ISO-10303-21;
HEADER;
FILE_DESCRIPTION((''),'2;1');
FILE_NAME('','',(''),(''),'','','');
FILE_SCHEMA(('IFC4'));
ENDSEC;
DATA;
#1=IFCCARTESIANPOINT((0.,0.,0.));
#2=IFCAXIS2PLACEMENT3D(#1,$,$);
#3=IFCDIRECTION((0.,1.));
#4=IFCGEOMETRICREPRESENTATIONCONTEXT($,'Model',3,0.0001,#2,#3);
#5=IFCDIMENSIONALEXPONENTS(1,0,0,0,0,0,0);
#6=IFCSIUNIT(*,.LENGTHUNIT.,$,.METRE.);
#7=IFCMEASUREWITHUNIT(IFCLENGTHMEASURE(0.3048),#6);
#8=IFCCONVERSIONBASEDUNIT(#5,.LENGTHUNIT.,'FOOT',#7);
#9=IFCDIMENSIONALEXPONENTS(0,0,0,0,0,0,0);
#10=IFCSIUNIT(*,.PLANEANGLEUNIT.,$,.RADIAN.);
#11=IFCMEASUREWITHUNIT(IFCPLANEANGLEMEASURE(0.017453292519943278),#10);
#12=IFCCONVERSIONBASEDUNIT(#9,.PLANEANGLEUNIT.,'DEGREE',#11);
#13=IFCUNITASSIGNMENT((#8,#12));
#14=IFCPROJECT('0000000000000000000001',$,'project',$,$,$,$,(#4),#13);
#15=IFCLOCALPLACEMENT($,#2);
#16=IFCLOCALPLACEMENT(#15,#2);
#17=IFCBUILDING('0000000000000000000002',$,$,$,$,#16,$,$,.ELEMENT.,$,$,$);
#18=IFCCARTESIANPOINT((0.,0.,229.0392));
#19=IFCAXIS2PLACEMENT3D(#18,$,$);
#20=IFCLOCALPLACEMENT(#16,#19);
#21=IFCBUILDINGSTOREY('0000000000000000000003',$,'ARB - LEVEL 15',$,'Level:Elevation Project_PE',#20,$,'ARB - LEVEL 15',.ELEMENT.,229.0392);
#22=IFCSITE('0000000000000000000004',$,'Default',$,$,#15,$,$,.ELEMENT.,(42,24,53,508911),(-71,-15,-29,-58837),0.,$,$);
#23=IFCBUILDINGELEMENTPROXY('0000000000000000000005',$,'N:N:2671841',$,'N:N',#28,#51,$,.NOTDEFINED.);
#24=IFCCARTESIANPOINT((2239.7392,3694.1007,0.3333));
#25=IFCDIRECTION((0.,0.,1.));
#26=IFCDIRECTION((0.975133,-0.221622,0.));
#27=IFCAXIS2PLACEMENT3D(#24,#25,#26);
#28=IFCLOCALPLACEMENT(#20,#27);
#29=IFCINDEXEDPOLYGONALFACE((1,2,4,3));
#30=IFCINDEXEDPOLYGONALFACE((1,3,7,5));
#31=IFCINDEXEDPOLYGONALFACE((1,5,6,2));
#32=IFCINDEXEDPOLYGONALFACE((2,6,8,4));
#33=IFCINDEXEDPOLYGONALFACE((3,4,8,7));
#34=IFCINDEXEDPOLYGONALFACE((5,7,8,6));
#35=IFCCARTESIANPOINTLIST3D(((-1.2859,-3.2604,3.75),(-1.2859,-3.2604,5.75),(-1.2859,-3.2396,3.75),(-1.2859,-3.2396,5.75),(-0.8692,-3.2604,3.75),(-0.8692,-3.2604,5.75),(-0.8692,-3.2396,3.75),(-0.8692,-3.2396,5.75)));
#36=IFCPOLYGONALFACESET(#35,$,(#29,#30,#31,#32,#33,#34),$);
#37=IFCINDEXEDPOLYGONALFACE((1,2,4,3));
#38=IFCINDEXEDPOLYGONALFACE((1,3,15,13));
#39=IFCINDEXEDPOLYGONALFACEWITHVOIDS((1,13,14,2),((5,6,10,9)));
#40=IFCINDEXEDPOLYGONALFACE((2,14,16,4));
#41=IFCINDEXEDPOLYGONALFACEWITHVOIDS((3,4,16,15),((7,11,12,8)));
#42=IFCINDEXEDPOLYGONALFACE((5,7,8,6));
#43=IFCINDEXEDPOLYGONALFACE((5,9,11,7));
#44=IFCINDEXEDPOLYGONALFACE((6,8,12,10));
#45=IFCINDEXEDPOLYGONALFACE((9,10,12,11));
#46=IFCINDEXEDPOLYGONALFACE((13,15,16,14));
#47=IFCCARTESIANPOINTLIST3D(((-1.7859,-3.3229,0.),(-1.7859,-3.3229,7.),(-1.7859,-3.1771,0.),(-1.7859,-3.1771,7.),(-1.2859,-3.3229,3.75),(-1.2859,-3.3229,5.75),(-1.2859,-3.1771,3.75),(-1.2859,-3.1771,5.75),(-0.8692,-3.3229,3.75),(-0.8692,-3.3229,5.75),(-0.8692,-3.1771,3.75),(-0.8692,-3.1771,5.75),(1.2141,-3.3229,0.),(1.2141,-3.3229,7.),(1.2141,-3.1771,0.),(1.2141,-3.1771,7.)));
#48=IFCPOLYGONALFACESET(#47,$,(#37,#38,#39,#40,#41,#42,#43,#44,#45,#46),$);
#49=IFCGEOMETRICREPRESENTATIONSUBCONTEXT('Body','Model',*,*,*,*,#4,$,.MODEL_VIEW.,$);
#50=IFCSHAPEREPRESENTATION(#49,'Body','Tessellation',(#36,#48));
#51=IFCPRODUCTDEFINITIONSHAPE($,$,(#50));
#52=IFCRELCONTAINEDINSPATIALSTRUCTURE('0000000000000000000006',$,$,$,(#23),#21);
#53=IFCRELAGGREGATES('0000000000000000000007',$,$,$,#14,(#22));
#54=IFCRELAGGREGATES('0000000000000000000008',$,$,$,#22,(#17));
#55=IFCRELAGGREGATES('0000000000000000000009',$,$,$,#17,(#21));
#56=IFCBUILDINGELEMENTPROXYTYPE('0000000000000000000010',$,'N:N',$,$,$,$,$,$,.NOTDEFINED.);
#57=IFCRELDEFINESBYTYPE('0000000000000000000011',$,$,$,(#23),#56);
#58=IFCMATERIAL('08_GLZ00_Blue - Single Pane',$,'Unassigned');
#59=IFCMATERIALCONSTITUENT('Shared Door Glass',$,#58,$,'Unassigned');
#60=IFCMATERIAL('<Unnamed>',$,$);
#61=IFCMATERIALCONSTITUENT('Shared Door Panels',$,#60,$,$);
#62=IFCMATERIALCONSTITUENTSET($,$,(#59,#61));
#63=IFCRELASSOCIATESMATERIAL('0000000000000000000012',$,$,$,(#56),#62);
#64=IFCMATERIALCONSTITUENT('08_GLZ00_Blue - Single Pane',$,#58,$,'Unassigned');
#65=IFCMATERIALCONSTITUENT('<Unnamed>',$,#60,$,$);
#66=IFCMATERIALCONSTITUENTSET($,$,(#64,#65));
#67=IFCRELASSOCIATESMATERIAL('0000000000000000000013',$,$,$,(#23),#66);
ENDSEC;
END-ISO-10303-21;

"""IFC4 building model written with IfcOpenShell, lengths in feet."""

from ifc_helpers import new_model, entity, si_unit, converted_unit, direction, frame, origin, place, context, subcontext, project, spatial, indexed_curve, outline, extrude, source, transform, mapped, material, constituent, constituent_set, type_object, type_shapes, element, save


model = new_model("IFC4")

# Units and contexts
model_context = context("Model", 3, precision=0.0001, world=origin(), true_north=direction((0.0, 1.0)))
body_context = subcontext(model_context, "Body", "Model", "MODEL_VIEW")
ifc_project = project(units=[converted_unit("LENGTHUNIT", "FOOT", entity("IfcLengthMeasure", 0.3048), si_unit("LENGTHUNIT", "METRE"), dimensions=[1, 0, 0, 0, 0, 0, 0]), converted_unit("PLANEANGLEUNIT", "DEGREE", entity("IfcPlaneAngleMeasure", 0.017453292519943278), si_unit("PLANEANGLEUNIT", "RADIAN"), dimensions=[0, 0, 0, 0, 0, 0, 0])], contexts=[model_context])

# Site, building, storey
site_placement = place(None, origin())
site = spatial("IfcSite", under=ifc_project, at=site_placement, Name="Default", CompositionType="ELEMENT", RefLatitude=(42, 24, 53, 508911), RefLongitude=(-71, -15, -29, -58837), RefElevation=0.0)
building_placement = place(site_placement, origin())
building = spatial("IfcBuilding", under=site, at=building_placement, CompositionType="ELEMENT")
storey_placement = place(building_placement, frame((0.0, 0.0, 229.0392)))
storey = spatial("IfcBuildingStorey", under=building, at=storey_placement, Name="ARB - LEVEL 15", ObjectType="Level:Elevation Project_PE", LongName="ARB - LEVEL 15", CompositionType="ELEMENT", Elevation=229.0392)

# Shared definitions
ifc_material_1 = material(Name="<Unnamed>")

# Building element proxy
ifc_material_2 = material(Name="08_GLZ00_Blue - Single Pane", Category="Unassigned")
ifc_constituent_1 = constituent(ifc_material_2, Name="08_GLZ00_Blue - Single Pane", Category="Unassigned")
ifc_constituent_2 = constituent(ifc_material_1, Name="<Unnamed>")
ifc_constituent_set_1 = constituent_set(constituents=[ifc_constituent_1, ifc_constituent_2])
ifc_constituent_3 = constituent(ifc_material_2, Name="Shared Door Glass", Category="Unassigned")
ifc_constituent_4 = constituent(ifc_material_1, Name="Shared Door Panels")
ifc_constituent_set_2 = constituent_set(constituents=[ifc_constituent_3, ifc_constituent_4])
building_element_proxy_type = type_object("IfcBuildingElementProxyType", Name="N:N", PredefinedType="NOTDEFINED", material=ifc_constituent_set_2)
shared_shape = source(origin(), body_context, "Body", "SweptSolid", [
    extrude(outline(indexed_curve([(-0.2083, -0.0104), (0.2083, -0.0104), (0.2083, 0.0104), (-0.2083, 0.0104), (-0.2083, -0.0104)], self_intersect=False)), frame((-1.0775, -3.25, 3.75), z_axis=(0.0, 0.0, 1.0), x_axis=(-1.0, 0.0, 0.0)), (0.0, 0.0, 1.0), 2.0),
    extrude(outline(indexed_curve([(-3.5, -1.5), (3.5, -1.5), (3.5, 1.5), (-3.5, 1.5), (-3.5, -1.5)], self_intersect=False), holes=[indexed_curve([(-2.25, 0.5833), (-2.25, 1.0), (-0.25, 1.0), (-0.25, 0.5833), (-2.25, 0.5833)], self_intersect=False)]), frame((-0.2859, -3.3229, 3.5), z_axis=(0.0, 1.0, 0.0), x_axis=(0.0, 0.0, -1.0)), (0.0, 0.0, 1.0), 0.1458),
])
type_shapes(building_element_proxy_type, [shared_shape])
proxy_placement = place(storey_placement, frame((2239.7392, 3694.1007, 0.3333), z_axis=(0.0, 0.0, 1.0), x_axis=(0.975133, -0.221622, 0.0)))
element("IfcBuildingElementProxy", 1, at=proxy_placement, inside=storey, type_object=building_element_proxy_type, material=ifc_constituent_set_1, Name="N:N:2671841", ObjectType="N:N", PredefinedType="NOTDEFINED", context=body_context, shape_type="MappedRepresentation", body=[
    mapped(shared_shape, transform((0.0, 0.0, 0.0), scale=1.0)),
])

save(model, "model.ifc")
